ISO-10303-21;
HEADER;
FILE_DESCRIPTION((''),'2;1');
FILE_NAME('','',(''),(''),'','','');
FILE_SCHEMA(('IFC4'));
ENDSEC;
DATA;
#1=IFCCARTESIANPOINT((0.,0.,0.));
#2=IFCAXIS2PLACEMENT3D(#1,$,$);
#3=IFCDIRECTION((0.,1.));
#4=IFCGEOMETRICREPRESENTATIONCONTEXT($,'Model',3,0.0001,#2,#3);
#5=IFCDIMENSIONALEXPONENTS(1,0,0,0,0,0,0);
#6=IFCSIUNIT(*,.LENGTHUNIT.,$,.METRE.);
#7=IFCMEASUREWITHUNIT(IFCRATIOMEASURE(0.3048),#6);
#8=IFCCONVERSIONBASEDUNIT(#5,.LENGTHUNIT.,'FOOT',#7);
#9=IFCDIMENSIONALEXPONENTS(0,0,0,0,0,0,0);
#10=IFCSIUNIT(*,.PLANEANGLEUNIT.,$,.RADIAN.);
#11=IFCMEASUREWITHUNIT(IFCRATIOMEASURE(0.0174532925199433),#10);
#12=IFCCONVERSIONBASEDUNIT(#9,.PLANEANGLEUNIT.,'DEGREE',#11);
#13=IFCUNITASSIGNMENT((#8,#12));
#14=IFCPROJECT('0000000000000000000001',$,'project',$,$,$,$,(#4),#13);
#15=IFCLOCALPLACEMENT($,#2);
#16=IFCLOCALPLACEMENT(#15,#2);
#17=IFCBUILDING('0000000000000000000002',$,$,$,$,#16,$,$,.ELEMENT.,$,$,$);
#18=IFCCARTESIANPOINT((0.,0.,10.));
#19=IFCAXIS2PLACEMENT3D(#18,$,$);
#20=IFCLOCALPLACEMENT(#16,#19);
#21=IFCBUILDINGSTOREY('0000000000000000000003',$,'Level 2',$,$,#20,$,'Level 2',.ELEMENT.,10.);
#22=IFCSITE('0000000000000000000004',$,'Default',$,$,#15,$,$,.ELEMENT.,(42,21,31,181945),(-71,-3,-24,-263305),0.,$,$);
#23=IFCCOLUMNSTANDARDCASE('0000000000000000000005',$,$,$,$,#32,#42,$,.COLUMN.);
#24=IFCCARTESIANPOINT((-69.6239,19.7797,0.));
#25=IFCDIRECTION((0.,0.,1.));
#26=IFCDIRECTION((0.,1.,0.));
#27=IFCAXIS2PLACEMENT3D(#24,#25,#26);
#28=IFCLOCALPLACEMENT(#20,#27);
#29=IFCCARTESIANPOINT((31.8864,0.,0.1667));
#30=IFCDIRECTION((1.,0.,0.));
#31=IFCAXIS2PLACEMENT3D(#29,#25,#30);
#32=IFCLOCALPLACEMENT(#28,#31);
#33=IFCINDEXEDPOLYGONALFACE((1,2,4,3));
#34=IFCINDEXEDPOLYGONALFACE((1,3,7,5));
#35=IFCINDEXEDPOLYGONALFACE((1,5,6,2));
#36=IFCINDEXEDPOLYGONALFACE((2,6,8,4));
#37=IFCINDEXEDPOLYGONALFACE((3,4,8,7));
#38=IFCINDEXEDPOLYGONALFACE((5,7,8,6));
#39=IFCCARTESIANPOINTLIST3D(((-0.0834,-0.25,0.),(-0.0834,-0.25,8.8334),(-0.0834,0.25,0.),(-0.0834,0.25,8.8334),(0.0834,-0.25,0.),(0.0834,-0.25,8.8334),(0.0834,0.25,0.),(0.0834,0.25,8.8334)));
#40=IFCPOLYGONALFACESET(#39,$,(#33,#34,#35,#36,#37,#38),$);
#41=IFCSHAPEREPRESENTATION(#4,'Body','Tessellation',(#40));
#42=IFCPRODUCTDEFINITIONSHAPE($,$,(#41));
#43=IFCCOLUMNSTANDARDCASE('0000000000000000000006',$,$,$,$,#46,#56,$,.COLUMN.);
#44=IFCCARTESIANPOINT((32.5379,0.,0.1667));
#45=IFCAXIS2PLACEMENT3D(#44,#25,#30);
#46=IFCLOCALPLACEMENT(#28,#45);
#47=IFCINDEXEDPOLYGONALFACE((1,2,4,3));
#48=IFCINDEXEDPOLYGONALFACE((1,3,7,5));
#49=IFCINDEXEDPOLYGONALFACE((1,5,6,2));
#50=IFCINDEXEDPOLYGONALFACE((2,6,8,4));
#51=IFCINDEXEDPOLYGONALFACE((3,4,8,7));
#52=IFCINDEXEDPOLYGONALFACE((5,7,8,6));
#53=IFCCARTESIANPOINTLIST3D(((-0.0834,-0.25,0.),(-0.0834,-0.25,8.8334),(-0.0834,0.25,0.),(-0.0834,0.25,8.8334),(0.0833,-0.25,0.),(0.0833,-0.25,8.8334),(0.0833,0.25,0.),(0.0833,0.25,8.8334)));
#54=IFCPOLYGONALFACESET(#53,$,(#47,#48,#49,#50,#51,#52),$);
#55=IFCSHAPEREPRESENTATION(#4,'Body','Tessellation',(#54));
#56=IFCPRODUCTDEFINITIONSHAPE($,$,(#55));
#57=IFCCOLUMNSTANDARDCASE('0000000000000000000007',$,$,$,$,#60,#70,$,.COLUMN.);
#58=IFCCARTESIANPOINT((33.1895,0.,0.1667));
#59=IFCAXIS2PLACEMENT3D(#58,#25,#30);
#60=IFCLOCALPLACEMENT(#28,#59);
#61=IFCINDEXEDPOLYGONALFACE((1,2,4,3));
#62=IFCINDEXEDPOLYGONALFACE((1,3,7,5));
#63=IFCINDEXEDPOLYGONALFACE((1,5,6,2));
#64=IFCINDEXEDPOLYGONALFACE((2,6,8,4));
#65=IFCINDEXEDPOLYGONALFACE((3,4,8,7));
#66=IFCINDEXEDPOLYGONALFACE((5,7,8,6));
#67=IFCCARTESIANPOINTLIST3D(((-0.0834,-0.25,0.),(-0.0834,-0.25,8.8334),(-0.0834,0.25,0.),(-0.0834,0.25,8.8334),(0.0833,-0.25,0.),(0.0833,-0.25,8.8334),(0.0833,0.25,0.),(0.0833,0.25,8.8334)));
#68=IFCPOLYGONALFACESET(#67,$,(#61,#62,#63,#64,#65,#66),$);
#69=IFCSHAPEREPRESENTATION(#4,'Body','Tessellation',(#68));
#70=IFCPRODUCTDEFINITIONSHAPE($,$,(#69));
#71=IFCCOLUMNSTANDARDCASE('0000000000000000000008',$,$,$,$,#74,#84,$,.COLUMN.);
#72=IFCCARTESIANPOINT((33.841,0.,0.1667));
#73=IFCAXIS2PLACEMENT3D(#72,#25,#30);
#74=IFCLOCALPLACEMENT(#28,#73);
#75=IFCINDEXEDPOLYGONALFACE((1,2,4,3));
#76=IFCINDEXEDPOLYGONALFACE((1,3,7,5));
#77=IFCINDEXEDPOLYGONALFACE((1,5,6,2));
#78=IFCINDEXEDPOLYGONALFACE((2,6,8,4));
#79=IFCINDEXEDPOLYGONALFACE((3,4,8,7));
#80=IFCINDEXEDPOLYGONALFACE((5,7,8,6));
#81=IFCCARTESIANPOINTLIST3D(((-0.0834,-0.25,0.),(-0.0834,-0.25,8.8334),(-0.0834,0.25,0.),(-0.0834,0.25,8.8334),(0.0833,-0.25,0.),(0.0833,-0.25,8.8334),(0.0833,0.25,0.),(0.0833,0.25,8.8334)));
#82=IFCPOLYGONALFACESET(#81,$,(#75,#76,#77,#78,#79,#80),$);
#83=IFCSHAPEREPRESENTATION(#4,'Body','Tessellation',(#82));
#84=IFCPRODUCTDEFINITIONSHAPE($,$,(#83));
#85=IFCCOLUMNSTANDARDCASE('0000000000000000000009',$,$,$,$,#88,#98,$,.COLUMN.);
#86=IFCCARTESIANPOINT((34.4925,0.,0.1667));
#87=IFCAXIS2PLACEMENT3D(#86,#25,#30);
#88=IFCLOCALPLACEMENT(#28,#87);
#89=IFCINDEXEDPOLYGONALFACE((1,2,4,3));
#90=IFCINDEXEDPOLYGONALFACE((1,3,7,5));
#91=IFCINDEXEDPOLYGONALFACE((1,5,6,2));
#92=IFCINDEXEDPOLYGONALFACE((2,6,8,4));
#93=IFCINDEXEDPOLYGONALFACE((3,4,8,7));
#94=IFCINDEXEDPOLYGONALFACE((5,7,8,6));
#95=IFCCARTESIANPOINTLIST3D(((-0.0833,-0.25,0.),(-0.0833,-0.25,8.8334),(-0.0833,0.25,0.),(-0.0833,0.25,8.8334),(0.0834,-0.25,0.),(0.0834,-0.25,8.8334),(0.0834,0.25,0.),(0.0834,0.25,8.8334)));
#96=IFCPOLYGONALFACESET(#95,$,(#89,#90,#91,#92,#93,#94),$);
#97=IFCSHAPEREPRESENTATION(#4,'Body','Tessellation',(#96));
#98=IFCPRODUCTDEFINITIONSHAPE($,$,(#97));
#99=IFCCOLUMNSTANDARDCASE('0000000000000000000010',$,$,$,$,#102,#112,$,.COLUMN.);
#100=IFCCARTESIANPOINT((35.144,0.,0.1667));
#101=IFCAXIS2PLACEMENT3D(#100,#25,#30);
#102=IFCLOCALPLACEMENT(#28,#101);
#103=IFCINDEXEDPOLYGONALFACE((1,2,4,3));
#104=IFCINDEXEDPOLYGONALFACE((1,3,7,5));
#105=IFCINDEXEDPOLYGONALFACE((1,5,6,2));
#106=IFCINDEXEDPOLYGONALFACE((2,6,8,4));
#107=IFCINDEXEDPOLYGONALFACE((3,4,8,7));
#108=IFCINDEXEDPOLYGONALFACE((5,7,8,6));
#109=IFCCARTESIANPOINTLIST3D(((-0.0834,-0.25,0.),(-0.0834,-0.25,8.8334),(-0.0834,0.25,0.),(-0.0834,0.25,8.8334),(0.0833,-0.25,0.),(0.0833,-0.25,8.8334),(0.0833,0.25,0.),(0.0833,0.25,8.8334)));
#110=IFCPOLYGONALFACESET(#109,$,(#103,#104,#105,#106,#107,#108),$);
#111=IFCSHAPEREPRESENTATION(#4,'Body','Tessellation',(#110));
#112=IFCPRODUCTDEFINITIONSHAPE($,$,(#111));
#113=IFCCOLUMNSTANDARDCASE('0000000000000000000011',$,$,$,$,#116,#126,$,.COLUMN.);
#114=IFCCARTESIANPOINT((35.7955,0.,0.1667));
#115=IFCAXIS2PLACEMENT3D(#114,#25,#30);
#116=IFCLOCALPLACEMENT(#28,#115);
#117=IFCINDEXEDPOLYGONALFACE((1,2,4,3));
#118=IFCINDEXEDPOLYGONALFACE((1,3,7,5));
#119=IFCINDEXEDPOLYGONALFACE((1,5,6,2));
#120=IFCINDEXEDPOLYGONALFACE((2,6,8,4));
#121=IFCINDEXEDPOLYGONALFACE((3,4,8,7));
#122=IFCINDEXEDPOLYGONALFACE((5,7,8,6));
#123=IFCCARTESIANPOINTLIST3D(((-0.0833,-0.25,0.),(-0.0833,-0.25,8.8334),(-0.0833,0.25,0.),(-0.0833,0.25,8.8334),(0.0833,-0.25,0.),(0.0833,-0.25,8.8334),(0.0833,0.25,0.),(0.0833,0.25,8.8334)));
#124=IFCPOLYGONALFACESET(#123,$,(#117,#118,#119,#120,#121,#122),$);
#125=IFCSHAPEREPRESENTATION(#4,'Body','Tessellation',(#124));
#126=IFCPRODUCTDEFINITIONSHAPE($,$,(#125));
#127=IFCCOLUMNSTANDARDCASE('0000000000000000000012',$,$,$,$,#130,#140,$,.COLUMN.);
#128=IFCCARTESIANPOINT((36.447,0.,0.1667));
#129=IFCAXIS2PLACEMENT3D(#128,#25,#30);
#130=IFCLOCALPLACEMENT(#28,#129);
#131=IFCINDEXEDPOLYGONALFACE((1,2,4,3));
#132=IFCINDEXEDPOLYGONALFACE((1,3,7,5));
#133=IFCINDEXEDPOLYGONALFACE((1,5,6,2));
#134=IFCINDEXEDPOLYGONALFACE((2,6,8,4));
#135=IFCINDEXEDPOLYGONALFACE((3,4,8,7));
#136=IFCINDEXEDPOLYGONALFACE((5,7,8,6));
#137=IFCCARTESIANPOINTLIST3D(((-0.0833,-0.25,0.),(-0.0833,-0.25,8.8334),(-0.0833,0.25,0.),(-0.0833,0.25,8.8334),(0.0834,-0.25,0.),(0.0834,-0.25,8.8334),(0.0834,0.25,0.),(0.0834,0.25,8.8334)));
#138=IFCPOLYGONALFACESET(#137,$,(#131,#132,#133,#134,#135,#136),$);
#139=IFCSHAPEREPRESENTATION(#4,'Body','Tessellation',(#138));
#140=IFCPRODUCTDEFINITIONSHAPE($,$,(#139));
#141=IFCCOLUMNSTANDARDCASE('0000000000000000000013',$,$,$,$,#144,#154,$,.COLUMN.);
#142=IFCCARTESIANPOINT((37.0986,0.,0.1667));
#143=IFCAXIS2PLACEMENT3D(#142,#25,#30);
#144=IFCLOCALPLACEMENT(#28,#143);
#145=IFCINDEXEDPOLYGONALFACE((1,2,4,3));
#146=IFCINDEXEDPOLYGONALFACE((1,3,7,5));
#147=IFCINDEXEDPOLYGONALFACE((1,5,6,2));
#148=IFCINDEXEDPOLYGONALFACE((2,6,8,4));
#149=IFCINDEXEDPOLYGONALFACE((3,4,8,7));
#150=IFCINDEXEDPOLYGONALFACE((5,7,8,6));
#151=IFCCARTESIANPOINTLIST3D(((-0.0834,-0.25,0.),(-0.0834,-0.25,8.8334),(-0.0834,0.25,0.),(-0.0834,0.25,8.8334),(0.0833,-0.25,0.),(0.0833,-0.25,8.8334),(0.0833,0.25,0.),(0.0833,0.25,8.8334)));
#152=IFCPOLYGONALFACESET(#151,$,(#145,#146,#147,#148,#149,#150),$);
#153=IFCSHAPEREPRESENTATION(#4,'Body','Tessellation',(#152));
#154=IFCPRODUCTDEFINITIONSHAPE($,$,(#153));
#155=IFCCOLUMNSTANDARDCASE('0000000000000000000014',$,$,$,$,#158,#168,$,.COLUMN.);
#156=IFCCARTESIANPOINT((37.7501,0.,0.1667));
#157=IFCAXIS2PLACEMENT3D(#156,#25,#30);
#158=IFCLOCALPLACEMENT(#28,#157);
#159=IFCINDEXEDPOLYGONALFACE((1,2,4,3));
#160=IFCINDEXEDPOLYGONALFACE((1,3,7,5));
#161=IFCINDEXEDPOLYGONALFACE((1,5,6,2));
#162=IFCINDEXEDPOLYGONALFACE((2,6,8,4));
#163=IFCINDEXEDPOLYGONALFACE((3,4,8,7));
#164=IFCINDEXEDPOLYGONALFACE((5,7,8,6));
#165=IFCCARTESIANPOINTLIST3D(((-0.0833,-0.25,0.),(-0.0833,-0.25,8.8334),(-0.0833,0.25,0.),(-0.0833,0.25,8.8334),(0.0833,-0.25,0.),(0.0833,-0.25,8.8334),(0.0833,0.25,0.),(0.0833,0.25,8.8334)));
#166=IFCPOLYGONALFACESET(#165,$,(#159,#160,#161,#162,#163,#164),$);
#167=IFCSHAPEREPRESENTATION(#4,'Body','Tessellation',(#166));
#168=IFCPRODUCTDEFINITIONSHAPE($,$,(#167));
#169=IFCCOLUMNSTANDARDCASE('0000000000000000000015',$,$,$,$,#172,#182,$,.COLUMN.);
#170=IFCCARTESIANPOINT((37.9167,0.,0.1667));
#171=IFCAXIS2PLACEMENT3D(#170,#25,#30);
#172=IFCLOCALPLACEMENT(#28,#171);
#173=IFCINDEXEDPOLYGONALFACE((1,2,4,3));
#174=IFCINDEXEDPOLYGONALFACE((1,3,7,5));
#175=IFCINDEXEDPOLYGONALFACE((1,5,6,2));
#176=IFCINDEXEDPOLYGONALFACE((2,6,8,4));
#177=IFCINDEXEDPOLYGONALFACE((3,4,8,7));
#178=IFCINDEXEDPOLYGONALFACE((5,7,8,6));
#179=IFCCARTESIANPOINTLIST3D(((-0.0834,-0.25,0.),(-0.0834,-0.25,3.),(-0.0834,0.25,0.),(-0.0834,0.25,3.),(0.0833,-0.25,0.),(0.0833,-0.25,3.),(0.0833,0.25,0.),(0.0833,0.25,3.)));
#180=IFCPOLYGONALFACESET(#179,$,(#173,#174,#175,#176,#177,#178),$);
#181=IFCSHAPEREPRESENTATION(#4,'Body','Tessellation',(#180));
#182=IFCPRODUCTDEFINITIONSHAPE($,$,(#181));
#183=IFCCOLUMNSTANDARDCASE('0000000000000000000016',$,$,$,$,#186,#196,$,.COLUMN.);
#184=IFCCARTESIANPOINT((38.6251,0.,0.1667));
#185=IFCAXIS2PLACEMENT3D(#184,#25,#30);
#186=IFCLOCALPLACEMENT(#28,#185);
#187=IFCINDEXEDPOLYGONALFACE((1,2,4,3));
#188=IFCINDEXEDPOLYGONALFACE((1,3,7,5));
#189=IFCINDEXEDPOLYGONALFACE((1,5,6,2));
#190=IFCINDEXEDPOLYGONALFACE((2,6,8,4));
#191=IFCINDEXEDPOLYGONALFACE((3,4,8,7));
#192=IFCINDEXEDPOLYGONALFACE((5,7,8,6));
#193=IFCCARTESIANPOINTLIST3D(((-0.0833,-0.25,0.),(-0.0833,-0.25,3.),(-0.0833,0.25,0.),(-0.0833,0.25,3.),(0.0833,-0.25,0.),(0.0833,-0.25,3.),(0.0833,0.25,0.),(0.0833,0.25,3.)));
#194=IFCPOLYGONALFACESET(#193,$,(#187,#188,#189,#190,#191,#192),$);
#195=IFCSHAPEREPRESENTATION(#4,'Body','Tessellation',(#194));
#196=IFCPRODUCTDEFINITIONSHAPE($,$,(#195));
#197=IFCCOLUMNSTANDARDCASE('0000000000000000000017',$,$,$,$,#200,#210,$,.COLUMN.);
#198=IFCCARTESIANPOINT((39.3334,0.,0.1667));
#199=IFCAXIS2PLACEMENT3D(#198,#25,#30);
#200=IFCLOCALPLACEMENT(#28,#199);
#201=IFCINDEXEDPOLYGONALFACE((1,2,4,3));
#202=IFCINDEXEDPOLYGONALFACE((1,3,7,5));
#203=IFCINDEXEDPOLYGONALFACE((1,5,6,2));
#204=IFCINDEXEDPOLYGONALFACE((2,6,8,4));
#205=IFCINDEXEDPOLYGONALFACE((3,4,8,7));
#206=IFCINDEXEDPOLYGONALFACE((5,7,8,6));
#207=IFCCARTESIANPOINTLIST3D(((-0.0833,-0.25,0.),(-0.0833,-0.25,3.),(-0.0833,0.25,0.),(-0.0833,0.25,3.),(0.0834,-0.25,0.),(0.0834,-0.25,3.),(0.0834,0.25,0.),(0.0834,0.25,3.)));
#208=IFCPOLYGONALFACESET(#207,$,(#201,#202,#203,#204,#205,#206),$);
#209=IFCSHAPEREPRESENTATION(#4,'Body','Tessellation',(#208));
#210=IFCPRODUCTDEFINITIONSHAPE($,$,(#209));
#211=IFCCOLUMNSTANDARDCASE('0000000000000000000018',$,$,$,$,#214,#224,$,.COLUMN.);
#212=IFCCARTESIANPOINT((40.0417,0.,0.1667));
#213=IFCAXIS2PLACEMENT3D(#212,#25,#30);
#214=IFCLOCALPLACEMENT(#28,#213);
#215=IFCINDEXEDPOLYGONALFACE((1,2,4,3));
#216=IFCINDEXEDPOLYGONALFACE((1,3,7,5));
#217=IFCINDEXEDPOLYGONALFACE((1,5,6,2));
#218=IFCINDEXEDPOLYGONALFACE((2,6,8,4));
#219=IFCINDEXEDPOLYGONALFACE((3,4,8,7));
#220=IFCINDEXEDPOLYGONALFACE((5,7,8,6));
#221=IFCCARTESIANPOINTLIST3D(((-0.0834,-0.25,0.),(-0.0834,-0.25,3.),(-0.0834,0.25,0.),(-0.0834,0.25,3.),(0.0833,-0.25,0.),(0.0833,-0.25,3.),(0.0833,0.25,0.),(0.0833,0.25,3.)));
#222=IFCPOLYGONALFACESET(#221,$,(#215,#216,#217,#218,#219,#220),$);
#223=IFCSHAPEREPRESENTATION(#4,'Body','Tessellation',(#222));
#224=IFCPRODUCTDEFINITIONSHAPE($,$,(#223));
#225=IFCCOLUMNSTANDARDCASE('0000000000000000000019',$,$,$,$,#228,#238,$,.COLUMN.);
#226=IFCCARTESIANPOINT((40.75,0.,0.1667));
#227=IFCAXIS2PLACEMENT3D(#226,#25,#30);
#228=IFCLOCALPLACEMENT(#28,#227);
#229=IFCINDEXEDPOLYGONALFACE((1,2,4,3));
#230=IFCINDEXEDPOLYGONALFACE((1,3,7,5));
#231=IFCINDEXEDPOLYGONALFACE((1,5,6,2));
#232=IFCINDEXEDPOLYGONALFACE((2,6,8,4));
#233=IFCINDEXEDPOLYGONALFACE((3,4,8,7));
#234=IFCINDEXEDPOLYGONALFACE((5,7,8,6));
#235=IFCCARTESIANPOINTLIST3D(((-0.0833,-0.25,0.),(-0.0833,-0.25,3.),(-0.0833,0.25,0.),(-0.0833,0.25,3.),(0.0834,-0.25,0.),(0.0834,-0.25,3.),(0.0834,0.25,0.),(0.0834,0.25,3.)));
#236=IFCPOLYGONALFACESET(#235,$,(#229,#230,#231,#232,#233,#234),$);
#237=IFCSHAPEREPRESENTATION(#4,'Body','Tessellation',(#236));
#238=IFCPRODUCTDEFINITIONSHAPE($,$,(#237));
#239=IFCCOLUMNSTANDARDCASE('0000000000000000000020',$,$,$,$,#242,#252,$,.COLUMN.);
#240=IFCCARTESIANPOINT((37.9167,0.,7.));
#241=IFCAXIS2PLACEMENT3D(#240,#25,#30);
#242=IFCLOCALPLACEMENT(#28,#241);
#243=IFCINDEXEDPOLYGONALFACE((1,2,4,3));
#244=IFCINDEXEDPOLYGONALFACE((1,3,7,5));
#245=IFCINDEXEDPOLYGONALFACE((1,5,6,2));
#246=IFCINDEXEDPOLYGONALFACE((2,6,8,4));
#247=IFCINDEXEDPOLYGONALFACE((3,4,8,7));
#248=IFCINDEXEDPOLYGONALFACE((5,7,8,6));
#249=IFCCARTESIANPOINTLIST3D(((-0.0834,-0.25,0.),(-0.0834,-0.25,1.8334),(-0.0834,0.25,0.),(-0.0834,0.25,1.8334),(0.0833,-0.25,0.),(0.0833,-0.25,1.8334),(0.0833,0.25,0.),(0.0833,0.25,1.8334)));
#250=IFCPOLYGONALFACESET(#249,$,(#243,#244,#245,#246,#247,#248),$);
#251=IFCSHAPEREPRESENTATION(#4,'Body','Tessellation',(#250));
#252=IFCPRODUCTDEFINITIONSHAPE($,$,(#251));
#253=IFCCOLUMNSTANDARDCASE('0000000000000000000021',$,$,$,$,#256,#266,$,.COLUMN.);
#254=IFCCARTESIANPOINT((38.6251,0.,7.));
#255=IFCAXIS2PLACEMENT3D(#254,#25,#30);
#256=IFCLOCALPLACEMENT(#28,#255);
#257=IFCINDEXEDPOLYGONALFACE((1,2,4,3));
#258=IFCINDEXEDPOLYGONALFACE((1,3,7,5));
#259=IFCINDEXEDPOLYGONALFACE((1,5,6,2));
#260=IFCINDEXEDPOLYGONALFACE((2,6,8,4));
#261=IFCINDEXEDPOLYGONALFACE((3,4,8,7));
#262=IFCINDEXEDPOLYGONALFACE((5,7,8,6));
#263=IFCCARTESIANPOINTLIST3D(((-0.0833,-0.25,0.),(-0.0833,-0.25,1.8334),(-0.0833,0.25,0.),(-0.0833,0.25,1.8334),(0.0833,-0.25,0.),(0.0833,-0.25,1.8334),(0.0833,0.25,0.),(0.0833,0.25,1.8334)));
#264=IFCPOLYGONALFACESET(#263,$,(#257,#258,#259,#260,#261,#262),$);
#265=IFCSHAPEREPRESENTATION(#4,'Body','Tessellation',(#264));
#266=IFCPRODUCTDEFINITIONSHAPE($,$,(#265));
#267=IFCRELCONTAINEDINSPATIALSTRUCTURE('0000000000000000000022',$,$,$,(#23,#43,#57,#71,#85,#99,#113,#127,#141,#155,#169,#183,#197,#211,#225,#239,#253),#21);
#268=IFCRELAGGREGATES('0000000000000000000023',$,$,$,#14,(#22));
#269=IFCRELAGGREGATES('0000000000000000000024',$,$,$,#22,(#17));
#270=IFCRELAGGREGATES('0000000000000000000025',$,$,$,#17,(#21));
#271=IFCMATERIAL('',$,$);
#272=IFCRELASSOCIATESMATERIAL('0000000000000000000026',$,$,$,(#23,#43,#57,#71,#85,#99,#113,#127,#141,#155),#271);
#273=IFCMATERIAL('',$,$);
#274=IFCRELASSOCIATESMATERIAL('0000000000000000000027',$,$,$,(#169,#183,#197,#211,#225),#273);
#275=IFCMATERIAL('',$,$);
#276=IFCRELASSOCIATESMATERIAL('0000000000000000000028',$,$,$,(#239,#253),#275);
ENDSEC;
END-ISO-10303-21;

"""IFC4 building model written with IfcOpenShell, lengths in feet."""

from ifc_helpers import new_model, entity, si_unit, converted_unit, direction, frame, origin, place, context, project, spatial, rectangle, extrude, material, element, save


model = new_model("IFC4")

# Units and contexts
model_context = context("Model", 3, precision=0.0001, world=origin(), true_north=direction((0.0, 1.0)))
ifc_project = project(units=[converted_unit("LENGTHUNIT", "FOOT", entity("IfcRatioMeasure", 0.3048), si_unit("LENGTHUNIT", "METRE"), dimensions=[1, 0, 0, 0, 0, 0, 0]), converted_unit("PLANEANGLEUNIT", "DEGREE", entity("IfcRatioMeasure", 0.0174532925199433), si_unit("PLANEANGLEUNIT", "RADIAN"), dimensions=[0, 0, 0, 0, 0, 0, 0])], contexts=[model_context])

# Site, building, storey
site_placement = place(None, origin())
site = spatial("IfcSite", under=ifc_project, at=site_placement, Name="Default", CompositionType="ELEMENT", RefLatitude=(42, 21, 31, 181945), RefLongitude=(-71, -3, -24, -263305), RefElevation=0.0)
building_placement = place(site_placement, origin())
building = spatial("IfcBuilding", under=site, at=building_placement, CompositionType="ELEMENT")
storey_placement = place(building_placement, frame((0.0, 0.0, 10.0)))
storey = spatial("IfcBuildingStorey", under=building, at=storey_placement, Name="Level 2", LongName="Level 2", CompositionType="ELEMENT", Elevation=10.0)

# Columns
ifc_material_1 = material(Name="")
placement = place(storey_placement, frame((-69.6239, 19.7797, 0.0), z_axis=(0.0, 0.0, 1.0), x_axis=(0.0, 1.0, 0.0)))
for number, where, z_axis, x_axis in (
    (1, (31.8864, 0.0, 0.1667), (0.0, 0.0, 1.0), (1.0, 0.0, 0.0)),
    (2, (32.5379, 0.0, 0.1667), (0.0, 0.0, 1.0), (1.0, 0.0, 0.0)),
    (3, (33.1895, 0.0, 0.1667), (0.0, 0.0, 1.0), (1.0, 0.0, 0.0)),
    (4, (33.841, 0.0, 0.1667), (0.0, 0.0, 1.0), (1.0, 0.0, 0.0)),
    (5, (34.4925, 0.0, 0.1667), (0.0, 0.0, 1.0), (1.0, 0.0, 0.0)),
    (6, (35.144, 0.0, 0.1667), (0.0, 0.0, 1.0), (1.0, 0.0, 0.0)),
    (7, (35.7955, 0.0, 0.1667), (0.0, 0.0, 1.0), (1.0, 0.0, 0.0)),
    (8, (36.447, 0.0, 0.1667), (0.0, 0.0, 1.0), (1.0, 0.0, 0.0)),
    (9, (37.0986, 0.0, 0.1667), (0.0, 0.0, 1.0), (1.0, 0.0, 0.0)),
    (10, (37.7501, 0.0, 0.1667), (0.0, 0.0, 1.0), (1.0, 0.0, 0.0)),
):
    element("IfcColumnStandardCase", number, at=place(placement, frame(where, z_axis=z_axis, x_axis=x_axis)), inside=storey, material=ifc_material_1, PredefinedType="COLUMN", context=model_context, shape_type="SweptSolid", body=[
        extrude(rectangle(XDim=0.1667, YDim=0.5), origin(), (0.0, 0.0, 1.0), 8.8334),
    ])
ifc_material_2 = material(Name="")
for number, where, z_axis, x_axis in (
    (11, (37.9167, 0.0, 0.1667), (0.0, 0.0, 1.0), (1.0, 0.0, 0.0)),
    (12, (38.6251, 0.0, 0.1667), (0.0, 0.0, 1.0), (1.0, 0.0, 0.0)),
    (13, (39.3334, 0.0, 0.1667), (0.0, 0.0, 1.0), (1.0, 0.0, 0.0)),
    (14, (40.0417, 0.0, 0.1667), (0.0, 0.0, 1.0), (1.0, 0.0, 0.0)),
    (15, (40.75, 0.0, 0.1667), (0.0, 0.0, 1.0), (1.0, 0.0, 0.0)),
):
    element("IfcColumnStandardCase", number, at=place(placement, frame(where, z_axis=z_axis, x_axis=x_axis)), inside=storey, material=ifc_material_2, PredefinedType="COLUMN", context=model_context, shape_type="SweptSolid", body=[
        extrude(rectangle(XDim=0.1667, YDim=0.5), origin(), (0.0, 0.0, 1.0), 3.0),
    ])
ifc_material_3 = material(Name="")
for number, where, z_axis, x_axis in (
    (16, (37.9167, 0.0, 7.0), (0.0, 0.0, 1.0), (1.0, 0.0, 0.0)),
    (17, (38.6251, 0.0, 7.0), (0.0, 0.0, 1.0), (1.0, 0.0, 0.0)),
):
    element("IfcColumnStandardCase", number, at=place(placement, frame(where, z_axis=z_axis, x_axis=x_axis)), inside=storey, material=ifc_material_3, PredefinedType="COLUMN", context=model_context, shape_type="SweptSolid", body=[
        extrude(rectangle(XDim=0.1667, YDim=0.5), origin(), (0.0, 0.0, 1.0), 1.8334),
    ])

save(model, "model.ifc")
